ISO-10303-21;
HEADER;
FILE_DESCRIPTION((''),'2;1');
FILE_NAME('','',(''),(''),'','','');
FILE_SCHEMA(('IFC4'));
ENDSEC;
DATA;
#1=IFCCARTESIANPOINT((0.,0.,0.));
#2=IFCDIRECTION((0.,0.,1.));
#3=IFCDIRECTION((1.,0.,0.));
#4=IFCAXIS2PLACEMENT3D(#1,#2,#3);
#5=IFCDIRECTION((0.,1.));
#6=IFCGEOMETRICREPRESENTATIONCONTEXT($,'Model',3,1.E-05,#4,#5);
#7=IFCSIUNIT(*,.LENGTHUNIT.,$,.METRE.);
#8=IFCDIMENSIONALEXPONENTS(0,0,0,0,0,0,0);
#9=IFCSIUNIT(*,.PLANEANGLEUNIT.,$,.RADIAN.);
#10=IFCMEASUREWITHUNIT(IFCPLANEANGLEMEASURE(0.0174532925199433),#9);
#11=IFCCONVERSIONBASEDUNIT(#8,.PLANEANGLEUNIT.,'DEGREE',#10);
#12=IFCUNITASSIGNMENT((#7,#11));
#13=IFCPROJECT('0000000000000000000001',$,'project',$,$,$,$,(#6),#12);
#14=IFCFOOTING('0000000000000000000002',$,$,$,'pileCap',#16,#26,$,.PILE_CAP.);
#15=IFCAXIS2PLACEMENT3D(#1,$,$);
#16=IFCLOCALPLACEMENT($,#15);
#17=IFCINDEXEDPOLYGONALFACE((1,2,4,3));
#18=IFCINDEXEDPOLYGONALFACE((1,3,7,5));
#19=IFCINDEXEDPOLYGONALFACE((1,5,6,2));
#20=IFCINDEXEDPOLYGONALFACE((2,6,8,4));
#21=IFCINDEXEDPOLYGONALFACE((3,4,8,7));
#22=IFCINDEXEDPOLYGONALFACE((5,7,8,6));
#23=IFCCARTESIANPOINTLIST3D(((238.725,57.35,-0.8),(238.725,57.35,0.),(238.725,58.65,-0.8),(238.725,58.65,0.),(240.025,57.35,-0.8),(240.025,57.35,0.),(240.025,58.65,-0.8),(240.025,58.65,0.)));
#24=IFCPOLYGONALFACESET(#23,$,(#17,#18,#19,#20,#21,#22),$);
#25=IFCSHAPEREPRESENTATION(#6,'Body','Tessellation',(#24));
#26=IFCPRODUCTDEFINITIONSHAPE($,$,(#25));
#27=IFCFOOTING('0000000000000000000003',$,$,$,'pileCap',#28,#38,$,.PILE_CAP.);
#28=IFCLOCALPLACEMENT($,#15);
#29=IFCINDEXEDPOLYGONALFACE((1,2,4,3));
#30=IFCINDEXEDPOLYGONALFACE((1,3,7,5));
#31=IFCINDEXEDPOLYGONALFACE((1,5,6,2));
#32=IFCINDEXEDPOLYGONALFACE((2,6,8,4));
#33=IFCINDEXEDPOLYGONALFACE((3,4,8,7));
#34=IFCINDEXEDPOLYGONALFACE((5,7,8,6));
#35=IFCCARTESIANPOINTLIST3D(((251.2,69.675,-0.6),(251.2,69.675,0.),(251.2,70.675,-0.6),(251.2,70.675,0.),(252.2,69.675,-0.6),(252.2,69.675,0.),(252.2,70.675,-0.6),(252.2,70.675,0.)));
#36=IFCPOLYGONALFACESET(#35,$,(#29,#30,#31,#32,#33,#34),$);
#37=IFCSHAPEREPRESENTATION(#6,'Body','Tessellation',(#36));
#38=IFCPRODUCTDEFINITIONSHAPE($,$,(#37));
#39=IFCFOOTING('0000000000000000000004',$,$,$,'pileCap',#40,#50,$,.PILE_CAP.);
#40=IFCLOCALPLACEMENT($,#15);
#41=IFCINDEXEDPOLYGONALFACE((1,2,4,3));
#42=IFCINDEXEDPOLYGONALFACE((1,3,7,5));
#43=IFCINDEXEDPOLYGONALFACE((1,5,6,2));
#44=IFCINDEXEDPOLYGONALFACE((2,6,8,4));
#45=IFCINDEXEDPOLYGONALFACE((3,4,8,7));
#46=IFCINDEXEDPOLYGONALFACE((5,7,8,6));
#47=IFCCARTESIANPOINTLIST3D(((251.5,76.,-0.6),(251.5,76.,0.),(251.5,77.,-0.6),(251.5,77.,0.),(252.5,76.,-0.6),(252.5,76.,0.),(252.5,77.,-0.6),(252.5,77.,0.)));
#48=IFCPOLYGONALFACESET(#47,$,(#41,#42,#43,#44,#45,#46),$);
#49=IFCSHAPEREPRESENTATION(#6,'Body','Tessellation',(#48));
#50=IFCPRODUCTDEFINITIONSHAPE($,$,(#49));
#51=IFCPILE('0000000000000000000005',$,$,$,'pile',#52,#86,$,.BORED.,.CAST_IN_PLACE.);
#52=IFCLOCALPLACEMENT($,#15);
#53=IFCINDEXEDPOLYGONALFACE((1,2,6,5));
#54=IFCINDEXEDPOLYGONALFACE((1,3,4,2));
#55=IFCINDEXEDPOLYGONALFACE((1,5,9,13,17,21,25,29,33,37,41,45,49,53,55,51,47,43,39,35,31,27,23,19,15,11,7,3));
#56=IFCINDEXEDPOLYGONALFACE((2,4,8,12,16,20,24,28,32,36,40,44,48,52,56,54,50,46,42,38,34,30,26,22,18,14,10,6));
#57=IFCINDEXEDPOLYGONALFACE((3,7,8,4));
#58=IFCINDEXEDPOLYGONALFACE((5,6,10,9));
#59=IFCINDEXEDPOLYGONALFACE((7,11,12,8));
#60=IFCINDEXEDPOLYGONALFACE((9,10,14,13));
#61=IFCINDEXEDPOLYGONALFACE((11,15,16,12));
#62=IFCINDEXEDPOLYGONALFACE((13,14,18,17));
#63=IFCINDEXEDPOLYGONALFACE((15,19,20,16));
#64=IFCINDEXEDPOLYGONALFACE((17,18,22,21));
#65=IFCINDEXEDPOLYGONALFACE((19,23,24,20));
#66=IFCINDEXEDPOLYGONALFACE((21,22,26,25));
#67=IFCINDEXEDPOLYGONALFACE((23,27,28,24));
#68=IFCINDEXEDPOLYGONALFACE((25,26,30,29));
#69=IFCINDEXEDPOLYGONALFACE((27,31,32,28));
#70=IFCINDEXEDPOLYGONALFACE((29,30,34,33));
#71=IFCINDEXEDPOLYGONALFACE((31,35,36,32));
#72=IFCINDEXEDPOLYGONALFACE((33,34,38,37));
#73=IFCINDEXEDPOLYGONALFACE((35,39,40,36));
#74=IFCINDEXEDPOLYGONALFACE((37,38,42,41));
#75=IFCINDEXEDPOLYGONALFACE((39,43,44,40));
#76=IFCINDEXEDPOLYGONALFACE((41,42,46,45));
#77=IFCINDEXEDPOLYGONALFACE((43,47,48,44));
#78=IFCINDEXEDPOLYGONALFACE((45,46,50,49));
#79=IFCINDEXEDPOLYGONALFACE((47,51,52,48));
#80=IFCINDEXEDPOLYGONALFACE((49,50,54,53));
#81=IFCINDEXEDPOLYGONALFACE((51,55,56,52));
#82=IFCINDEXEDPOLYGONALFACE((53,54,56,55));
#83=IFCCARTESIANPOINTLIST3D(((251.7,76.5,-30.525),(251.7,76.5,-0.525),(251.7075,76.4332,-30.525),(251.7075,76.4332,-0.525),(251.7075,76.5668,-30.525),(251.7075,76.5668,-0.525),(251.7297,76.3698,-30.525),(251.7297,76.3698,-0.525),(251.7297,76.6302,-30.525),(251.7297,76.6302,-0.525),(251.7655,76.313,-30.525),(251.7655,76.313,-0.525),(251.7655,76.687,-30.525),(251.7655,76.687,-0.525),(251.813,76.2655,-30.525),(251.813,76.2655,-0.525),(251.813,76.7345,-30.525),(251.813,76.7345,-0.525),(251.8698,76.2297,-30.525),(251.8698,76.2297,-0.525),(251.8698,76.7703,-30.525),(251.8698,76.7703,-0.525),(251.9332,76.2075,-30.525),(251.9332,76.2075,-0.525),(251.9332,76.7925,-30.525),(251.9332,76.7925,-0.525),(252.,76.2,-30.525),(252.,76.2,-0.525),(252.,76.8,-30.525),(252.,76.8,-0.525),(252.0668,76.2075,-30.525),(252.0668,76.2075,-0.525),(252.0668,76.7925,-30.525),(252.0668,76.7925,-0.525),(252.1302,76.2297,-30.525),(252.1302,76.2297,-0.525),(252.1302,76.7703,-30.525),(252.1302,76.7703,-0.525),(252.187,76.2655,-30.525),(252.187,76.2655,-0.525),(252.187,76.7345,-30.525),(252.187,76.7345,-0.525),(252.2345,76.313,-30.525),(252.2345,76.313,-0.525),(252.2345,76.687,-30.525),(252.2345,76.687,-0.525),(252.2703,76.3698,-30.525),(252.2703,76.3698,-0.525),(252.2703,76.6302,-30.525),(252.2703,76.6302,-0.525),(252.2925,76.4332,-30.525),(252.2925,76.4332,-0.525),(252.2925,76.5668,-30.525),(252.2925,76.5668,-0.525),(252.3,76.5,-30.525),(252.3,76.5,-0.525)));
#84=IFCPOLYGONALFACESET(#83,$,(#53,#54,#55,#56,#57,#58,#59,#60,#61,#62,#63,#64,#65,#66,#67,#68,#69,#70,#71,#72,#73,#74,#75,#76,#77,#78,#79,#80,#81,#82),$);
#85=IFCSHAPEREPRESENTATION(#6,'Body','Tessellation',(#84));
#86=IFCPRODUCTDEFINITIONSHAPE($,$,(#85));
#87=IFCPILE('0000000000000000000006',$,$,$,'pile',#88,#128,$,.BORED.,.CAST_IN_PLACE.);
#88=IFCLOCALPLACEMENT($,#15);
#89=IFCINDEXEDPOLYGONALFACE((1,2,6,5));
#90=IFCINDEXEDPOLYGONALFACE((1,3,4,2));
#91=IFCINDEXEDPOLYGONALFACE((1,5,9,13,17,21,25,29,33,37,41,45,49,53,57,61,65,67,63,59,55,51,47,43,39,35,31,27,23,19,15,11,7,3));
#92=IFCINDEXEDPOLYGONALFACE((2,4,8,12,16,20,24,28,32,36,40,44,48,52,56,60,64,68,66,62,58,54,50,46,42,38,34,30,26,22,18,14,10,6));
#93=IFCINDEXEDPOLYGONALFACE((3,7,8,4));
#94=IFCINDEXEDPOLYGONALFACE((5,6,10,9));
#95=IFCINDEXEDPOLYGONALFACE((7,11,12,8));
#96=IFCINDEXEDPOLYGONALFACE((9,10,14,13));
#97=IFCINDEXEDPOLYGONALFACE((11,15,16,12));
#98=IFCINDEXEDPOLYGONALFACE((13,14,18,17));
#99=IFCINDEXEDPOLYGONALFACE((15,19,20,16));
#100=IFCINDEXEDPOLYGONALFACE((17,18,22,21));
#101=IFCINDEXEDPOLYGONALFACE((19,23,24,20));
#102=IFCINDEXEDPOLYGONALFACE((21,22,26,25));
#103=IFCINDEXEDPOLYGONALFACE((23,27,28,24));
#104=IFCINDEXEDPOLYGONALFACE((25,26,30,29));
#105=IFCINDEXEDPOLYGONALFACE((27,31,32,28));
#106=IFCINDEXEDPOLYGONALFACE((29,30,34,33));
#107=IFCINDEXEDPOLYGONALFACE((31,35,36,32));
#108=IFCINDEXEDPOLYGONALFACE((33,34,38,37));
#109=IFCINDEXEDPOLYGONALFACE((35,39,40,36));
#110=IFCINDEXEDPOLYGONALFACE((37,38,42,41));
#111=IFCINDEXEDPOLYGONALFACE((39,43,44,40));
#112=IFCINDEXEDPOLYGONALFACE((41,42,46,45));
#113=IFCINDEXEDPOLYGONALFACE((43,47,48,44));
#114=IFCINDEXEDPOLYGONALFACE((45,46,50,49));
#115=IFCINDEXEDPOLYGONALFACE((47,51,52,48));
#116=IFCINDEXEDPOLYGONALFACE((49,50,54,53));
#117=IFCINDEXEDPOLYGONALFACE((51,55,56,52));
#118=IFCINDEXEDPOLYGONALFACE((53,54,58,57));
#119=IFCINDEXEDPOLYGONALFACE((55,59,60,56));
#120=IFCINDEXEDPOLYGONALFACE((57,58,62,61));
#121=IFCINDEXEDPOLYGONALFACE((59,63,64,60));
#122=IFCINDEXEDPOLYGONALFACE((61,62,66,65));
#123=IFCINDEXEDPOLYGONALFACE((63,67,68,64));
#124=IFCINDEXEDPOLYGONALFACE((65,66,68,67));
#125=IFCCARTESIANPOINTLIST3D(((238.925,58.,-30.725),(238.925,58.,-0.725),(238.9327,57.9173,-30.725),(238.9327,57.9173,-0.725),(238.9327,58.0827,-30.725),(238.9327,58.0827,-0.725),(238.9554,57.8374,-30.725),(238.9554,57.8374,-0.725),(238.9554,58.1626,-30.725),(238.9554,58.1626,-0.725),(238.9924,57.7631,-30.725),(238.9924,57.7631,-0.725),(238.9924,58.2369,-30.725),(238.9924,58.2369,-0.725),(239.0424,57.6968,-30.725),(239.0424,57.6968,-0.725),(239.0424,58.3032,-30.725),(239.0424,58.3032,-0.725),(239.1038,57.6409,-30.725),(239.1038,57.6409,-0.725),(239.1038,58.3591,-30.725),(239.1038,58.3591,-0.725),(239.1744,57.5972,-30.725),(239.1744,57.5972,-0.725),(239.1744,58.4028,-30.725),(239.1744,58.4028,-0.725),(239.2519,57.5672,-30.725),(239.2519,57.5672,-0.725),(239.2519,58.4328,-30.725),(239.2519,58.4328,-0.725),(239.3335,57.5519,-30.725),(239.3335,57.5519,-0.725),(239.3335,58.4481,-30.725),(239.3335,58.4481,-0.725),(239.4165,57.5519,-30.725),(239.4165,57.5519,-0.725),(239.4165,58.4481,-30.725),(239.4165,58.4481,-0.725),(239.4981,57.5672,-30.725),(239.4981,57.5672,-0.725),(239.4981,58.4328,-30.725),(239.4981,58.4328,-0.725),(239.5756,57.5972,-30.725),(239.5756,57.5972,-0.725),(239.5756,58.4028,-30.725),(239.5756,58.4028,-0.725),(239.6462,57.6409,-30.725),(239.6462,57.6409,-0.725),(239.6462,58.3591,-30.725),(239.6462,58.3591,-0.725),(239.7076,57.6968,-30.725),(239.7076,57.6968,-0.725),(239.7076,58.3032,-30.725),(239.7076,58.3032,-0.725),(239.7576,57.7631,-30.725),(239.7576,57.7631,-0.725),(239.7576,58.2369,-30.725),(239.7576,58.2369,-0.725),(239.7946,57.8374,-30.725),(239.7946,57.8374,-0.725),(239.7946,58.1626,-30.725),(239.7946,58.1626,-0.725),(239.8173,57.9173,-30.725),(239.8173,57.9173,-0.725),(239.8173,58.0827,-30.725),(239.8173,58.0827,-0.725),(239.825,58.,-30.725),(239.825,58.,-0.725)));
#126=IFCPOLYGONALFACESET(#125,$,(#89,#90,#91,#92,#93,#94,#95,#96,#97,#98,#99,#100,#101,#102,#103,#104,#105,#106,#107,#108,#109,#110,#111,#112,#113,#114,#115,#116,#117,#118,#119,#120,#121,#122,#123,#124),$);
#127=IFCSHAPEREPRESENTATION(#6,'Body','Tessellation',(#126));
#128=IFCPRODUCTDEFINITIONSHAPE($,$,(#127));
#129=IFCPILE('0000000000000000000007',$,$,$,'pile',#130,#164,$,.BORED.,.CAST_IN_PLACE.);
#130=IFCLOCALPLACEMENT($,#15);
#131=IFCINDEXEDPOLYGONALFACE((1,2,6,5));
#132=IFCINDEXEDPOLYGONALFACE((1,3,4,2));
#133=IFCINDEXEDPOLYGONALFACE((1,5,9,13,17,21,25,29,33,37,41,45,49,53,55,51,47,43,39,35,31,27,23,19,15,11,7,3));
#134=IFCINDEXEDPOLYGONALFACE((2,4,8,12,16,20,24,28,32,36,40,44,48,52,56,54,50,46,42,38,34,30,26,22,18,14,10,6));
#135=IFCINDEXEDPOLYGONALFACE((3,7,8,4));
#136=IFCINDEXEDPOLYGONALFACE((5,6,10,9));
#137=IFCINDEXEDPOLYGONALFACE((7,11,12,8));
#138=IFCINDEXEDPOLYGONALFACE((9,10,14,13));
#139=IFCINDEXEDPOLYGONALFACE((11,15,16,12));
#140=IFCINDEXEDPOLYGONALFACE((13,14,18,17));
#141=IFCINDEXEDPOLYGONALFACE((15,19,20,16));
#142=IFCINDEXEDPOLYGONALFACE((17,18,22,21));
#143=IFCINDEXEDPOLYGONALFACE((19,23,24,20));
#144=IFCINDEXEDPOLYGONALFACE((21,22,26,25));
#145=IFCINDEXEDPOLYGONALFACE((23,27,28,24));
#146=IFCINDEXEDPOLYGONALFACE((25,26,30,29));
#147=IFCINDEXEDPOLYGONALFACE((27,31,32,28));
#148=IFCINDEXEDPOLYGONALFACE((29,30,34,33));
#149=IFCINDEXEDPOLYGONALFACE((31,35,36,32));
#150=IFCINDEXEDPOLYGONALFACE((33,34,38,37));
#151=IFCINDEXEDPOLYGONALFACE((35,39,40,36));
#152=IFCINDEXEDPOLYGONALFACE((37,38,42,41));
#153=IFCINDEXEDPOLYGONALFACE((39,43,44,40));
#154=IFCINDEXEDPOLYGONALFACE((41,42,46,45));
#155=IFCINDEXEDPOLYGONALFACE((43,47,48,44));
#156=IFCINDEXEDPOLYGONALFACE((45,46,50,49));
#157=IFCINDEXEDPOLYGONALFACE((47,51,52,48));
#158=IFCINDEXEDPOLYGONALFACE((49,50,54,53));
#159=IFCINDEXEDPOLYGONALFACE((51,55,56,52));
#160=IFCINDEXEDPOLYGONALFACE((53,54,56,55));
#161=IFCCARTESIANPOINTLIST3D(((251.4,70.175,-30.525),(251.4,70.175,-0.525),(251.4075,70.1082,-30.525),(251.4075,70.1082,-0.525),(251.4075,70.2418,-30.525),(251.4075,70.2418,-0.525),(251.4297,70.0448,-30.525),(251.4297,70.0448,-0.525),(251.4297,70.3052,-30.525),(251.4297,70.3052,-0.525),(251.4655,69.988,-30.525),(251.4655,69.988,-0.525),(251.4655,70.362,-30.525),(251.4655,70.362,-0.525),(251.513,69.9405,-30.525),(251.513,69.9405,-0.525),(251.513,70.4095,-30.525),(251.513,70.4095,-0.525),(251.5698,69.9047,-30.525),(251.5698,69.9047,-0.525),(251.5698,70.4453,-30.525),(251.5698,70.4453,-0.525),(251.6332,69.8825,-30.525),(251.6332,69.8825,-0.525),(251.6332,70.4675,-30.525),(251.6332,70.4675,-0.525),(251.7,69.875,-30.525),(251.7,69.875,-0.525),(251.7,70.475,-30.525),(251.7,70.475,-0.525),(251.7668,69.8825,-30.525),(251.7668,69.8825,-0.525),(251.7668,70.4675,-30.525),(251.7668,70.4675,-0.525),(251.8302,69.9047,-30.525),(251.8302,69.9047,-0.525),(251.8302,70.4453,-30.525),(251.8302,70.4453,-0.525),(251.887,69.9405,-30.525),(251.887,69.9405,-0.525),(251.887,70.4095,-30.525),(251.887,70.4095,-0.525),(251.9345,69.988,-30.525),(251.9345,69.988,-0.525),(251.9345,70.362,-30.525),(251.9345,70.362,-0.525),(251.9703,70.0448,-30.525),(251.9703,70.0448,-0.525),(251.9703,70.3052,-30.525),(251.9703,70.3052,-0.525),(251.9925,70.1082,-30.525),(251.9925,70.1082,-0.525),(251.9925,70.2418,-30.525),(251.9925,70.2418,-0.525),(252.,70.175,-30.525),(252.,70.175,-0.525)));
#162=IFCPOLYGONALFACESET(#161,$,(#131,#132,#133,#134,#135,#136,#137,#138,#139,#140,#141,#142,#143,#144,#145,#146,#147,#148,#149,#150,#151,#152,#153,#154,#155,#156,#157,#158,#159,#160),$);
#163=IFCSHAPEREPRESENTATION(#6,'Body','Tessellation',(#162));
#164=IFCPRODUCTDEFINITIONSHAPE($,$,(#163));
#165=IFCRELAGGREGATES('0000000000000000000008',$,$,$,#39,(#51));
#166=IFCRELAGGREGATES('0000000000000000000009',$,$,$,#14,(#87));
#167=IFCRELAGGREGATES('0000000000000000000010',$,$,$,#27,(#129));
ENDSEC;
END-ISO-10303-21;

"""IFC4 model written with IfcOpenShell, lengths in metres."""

from ifc_helpers import new_model, entity, si_unit, converted_unit, direction, frame, origin_with_axes, place, context, project, polyline, circle_curve, parameter, trimmed, segment, composite_curve, outline, extrude, element, aggregate, save


model = new_model("IFC4")

# Units and contexts
model_context = context("Model", 3, precision=1e-05, world=origin_with_axes(), true_north=direction((0.0, 1.0)))
ifc_project = project(units=[si_unit("LENGTHUNIT", "METRE"), converted_unit("PLANEANGLEUNIT", "DEGREE", entity("IfcPlaneAngleMeasure", 0.0174532925199433), si_unit("PLANEANGLEUNIT", "RADIAN"), dimensions=[0, 0, 0, 0, 0, 0, 0])], contexts=[model_context])

# Footings
placement_1 = place(None, origin_with_axes())
placement_2 = place(placement_1, origin_with_axes())
footing_1_placement = place(placement_2, frame((239.375, 58.0, -0.8), z_axis=(0.0, 0.0, 1.0), x_axis=(1.0, 0.0, 0.0)))
footing_1 = element("IfcFooting", 1, at=footing_1_placement, ObjectType="pileCap", PredefinedType="PILE_CAP", context=model_context, body=[
    extrude(outline(polyline([(0.65, -0.65, 0.0), (0.65, 0.65, 0.0), (-0.65, 0.65, 0.0), (-0.65, -0.65, 0.0), (0.65, -0.65, 0.0)])), origin_with_axes(), (0.0, 0.0, 1.0), 0.8),
])
footing_2_placement = place(placement_2, frame((251.7, 70.175, -0.6), z_axis=(0.0, 0.0, 1.0), x_axis=(1.0, 0.0, 0.0)))
footing_2 = element("IfcFooting", 2, at=footing_2_placement, ObjectType="pileCap", PredefinedType="PILE_CAP", context=model_context, body=[
    extrude(outline(polyline([(0.5, -0.5, 0.0), (0.5, 0.5, 0.0), (-0.5, 0.5, 0.0), (-0.5, -0.5, 0.0), (0.5, -0.5, 0.0)])), origin_with_axes(), (0.0, 0.0, 1.0), 0.6),
])
footing_3_placement = place(placement_2, frame((252.0, 76.5, -0.6), z_axis=(0.0, 0.0, 1.0), x_axis=(1.0, 0.0, 0.0)))
footing_3 = element("IfcFooting", 3, at=footing_3_placement, ObjectType="pileCap", PredefinedType="PILE_CAP", context=model_context, body=[
    extrude(outline(polyline([(0.5, -0.5, 0.0), (0.5, 0.5, 0.0), (-0.5, 0.5, 0.0), (-0.5, -0.5, 0.0), (0.5, -0.5, 0.0)])), origin_with_axes(), (0.0, 0.0, 1.0), 0.6),
])

# Piles
pile_1_placement = place(footing_3_placement, frame((0.0, 0.0, -29.925), z_axis=(0.0, 0.0, 1.0), x_axis=(1.0, 0.0, 0.0)))
pile_1 = element("IfcPile", 4, at=pile_1_placement, ObjectType="pile", ConstructionType="CAST_IN_PLACE", PredefinedType="BORED", context=model_context, body=[
    extrude(outline(composite_curve([segment(trimmed(circle_curve(origin_with_axes(), 0.3), [parameter(0.0)], [parameter(360.0)], True, "PARAMETER"), True, "CONTINUOUS")], self_intersect=False)), origin_with_axes(), (0.0, 0.0, 1.0), 30.0),
])
aggregate(footing_3, [pile_1])
pile_2_placement = place(footing_1_placement, frame((0.0, 0.0, -29.925), z_axis=(0.0, 0.0, 1.0), x_axis=(1.0, 0.0, 0.0)))
pile_2 = element("IfcPile", 5, at=pile_2_placement, ObjectType="pile", ConstructionType="CAST_IN_PLACE", PredefinedType="BORED", context=model_context, body=[
    extrude(outline(composite_curve([segment(trimmed(circle_curve(origin_with_axes(), 0.45), [parameter(0.0)], [parameter(360.0)], True, "PARAMETER"), True, "CONTINUOUS")], self_intersect=False)), origin_with_axes(), (0.0, 0.0, 1.0), 30.0),
])
aggregate(footing_1, [pile_2])
pile_3_placement = place(footing_2_placement, frame((0.0, 0.0, -29.925), z_axis=(0.0, 0.0, 1.0), x_axis=(1.0, 0.0, 0.0)))
pile_3 = element("IfcPile", 6, at=pile_3_placement, ObjectType="pile", ConstructionType="CAST_IN_PLACE", PredefinedType="BORED", context=model_context, body=[
    extrude(outline(composite_curve([segment(trimmed(circle_curve(origin_with_axes(), 0.3), [parameter(0.0)], [parameter(360.0)], True, "PARAMETER"), True, "CONTINUOUS")], self_intersect=False)), origin_with_axes(), (0.0, 0.0, 1.0), 30.0),
])
aggregate(footing_2, [pile_3])

save(model, "model.ifc")
